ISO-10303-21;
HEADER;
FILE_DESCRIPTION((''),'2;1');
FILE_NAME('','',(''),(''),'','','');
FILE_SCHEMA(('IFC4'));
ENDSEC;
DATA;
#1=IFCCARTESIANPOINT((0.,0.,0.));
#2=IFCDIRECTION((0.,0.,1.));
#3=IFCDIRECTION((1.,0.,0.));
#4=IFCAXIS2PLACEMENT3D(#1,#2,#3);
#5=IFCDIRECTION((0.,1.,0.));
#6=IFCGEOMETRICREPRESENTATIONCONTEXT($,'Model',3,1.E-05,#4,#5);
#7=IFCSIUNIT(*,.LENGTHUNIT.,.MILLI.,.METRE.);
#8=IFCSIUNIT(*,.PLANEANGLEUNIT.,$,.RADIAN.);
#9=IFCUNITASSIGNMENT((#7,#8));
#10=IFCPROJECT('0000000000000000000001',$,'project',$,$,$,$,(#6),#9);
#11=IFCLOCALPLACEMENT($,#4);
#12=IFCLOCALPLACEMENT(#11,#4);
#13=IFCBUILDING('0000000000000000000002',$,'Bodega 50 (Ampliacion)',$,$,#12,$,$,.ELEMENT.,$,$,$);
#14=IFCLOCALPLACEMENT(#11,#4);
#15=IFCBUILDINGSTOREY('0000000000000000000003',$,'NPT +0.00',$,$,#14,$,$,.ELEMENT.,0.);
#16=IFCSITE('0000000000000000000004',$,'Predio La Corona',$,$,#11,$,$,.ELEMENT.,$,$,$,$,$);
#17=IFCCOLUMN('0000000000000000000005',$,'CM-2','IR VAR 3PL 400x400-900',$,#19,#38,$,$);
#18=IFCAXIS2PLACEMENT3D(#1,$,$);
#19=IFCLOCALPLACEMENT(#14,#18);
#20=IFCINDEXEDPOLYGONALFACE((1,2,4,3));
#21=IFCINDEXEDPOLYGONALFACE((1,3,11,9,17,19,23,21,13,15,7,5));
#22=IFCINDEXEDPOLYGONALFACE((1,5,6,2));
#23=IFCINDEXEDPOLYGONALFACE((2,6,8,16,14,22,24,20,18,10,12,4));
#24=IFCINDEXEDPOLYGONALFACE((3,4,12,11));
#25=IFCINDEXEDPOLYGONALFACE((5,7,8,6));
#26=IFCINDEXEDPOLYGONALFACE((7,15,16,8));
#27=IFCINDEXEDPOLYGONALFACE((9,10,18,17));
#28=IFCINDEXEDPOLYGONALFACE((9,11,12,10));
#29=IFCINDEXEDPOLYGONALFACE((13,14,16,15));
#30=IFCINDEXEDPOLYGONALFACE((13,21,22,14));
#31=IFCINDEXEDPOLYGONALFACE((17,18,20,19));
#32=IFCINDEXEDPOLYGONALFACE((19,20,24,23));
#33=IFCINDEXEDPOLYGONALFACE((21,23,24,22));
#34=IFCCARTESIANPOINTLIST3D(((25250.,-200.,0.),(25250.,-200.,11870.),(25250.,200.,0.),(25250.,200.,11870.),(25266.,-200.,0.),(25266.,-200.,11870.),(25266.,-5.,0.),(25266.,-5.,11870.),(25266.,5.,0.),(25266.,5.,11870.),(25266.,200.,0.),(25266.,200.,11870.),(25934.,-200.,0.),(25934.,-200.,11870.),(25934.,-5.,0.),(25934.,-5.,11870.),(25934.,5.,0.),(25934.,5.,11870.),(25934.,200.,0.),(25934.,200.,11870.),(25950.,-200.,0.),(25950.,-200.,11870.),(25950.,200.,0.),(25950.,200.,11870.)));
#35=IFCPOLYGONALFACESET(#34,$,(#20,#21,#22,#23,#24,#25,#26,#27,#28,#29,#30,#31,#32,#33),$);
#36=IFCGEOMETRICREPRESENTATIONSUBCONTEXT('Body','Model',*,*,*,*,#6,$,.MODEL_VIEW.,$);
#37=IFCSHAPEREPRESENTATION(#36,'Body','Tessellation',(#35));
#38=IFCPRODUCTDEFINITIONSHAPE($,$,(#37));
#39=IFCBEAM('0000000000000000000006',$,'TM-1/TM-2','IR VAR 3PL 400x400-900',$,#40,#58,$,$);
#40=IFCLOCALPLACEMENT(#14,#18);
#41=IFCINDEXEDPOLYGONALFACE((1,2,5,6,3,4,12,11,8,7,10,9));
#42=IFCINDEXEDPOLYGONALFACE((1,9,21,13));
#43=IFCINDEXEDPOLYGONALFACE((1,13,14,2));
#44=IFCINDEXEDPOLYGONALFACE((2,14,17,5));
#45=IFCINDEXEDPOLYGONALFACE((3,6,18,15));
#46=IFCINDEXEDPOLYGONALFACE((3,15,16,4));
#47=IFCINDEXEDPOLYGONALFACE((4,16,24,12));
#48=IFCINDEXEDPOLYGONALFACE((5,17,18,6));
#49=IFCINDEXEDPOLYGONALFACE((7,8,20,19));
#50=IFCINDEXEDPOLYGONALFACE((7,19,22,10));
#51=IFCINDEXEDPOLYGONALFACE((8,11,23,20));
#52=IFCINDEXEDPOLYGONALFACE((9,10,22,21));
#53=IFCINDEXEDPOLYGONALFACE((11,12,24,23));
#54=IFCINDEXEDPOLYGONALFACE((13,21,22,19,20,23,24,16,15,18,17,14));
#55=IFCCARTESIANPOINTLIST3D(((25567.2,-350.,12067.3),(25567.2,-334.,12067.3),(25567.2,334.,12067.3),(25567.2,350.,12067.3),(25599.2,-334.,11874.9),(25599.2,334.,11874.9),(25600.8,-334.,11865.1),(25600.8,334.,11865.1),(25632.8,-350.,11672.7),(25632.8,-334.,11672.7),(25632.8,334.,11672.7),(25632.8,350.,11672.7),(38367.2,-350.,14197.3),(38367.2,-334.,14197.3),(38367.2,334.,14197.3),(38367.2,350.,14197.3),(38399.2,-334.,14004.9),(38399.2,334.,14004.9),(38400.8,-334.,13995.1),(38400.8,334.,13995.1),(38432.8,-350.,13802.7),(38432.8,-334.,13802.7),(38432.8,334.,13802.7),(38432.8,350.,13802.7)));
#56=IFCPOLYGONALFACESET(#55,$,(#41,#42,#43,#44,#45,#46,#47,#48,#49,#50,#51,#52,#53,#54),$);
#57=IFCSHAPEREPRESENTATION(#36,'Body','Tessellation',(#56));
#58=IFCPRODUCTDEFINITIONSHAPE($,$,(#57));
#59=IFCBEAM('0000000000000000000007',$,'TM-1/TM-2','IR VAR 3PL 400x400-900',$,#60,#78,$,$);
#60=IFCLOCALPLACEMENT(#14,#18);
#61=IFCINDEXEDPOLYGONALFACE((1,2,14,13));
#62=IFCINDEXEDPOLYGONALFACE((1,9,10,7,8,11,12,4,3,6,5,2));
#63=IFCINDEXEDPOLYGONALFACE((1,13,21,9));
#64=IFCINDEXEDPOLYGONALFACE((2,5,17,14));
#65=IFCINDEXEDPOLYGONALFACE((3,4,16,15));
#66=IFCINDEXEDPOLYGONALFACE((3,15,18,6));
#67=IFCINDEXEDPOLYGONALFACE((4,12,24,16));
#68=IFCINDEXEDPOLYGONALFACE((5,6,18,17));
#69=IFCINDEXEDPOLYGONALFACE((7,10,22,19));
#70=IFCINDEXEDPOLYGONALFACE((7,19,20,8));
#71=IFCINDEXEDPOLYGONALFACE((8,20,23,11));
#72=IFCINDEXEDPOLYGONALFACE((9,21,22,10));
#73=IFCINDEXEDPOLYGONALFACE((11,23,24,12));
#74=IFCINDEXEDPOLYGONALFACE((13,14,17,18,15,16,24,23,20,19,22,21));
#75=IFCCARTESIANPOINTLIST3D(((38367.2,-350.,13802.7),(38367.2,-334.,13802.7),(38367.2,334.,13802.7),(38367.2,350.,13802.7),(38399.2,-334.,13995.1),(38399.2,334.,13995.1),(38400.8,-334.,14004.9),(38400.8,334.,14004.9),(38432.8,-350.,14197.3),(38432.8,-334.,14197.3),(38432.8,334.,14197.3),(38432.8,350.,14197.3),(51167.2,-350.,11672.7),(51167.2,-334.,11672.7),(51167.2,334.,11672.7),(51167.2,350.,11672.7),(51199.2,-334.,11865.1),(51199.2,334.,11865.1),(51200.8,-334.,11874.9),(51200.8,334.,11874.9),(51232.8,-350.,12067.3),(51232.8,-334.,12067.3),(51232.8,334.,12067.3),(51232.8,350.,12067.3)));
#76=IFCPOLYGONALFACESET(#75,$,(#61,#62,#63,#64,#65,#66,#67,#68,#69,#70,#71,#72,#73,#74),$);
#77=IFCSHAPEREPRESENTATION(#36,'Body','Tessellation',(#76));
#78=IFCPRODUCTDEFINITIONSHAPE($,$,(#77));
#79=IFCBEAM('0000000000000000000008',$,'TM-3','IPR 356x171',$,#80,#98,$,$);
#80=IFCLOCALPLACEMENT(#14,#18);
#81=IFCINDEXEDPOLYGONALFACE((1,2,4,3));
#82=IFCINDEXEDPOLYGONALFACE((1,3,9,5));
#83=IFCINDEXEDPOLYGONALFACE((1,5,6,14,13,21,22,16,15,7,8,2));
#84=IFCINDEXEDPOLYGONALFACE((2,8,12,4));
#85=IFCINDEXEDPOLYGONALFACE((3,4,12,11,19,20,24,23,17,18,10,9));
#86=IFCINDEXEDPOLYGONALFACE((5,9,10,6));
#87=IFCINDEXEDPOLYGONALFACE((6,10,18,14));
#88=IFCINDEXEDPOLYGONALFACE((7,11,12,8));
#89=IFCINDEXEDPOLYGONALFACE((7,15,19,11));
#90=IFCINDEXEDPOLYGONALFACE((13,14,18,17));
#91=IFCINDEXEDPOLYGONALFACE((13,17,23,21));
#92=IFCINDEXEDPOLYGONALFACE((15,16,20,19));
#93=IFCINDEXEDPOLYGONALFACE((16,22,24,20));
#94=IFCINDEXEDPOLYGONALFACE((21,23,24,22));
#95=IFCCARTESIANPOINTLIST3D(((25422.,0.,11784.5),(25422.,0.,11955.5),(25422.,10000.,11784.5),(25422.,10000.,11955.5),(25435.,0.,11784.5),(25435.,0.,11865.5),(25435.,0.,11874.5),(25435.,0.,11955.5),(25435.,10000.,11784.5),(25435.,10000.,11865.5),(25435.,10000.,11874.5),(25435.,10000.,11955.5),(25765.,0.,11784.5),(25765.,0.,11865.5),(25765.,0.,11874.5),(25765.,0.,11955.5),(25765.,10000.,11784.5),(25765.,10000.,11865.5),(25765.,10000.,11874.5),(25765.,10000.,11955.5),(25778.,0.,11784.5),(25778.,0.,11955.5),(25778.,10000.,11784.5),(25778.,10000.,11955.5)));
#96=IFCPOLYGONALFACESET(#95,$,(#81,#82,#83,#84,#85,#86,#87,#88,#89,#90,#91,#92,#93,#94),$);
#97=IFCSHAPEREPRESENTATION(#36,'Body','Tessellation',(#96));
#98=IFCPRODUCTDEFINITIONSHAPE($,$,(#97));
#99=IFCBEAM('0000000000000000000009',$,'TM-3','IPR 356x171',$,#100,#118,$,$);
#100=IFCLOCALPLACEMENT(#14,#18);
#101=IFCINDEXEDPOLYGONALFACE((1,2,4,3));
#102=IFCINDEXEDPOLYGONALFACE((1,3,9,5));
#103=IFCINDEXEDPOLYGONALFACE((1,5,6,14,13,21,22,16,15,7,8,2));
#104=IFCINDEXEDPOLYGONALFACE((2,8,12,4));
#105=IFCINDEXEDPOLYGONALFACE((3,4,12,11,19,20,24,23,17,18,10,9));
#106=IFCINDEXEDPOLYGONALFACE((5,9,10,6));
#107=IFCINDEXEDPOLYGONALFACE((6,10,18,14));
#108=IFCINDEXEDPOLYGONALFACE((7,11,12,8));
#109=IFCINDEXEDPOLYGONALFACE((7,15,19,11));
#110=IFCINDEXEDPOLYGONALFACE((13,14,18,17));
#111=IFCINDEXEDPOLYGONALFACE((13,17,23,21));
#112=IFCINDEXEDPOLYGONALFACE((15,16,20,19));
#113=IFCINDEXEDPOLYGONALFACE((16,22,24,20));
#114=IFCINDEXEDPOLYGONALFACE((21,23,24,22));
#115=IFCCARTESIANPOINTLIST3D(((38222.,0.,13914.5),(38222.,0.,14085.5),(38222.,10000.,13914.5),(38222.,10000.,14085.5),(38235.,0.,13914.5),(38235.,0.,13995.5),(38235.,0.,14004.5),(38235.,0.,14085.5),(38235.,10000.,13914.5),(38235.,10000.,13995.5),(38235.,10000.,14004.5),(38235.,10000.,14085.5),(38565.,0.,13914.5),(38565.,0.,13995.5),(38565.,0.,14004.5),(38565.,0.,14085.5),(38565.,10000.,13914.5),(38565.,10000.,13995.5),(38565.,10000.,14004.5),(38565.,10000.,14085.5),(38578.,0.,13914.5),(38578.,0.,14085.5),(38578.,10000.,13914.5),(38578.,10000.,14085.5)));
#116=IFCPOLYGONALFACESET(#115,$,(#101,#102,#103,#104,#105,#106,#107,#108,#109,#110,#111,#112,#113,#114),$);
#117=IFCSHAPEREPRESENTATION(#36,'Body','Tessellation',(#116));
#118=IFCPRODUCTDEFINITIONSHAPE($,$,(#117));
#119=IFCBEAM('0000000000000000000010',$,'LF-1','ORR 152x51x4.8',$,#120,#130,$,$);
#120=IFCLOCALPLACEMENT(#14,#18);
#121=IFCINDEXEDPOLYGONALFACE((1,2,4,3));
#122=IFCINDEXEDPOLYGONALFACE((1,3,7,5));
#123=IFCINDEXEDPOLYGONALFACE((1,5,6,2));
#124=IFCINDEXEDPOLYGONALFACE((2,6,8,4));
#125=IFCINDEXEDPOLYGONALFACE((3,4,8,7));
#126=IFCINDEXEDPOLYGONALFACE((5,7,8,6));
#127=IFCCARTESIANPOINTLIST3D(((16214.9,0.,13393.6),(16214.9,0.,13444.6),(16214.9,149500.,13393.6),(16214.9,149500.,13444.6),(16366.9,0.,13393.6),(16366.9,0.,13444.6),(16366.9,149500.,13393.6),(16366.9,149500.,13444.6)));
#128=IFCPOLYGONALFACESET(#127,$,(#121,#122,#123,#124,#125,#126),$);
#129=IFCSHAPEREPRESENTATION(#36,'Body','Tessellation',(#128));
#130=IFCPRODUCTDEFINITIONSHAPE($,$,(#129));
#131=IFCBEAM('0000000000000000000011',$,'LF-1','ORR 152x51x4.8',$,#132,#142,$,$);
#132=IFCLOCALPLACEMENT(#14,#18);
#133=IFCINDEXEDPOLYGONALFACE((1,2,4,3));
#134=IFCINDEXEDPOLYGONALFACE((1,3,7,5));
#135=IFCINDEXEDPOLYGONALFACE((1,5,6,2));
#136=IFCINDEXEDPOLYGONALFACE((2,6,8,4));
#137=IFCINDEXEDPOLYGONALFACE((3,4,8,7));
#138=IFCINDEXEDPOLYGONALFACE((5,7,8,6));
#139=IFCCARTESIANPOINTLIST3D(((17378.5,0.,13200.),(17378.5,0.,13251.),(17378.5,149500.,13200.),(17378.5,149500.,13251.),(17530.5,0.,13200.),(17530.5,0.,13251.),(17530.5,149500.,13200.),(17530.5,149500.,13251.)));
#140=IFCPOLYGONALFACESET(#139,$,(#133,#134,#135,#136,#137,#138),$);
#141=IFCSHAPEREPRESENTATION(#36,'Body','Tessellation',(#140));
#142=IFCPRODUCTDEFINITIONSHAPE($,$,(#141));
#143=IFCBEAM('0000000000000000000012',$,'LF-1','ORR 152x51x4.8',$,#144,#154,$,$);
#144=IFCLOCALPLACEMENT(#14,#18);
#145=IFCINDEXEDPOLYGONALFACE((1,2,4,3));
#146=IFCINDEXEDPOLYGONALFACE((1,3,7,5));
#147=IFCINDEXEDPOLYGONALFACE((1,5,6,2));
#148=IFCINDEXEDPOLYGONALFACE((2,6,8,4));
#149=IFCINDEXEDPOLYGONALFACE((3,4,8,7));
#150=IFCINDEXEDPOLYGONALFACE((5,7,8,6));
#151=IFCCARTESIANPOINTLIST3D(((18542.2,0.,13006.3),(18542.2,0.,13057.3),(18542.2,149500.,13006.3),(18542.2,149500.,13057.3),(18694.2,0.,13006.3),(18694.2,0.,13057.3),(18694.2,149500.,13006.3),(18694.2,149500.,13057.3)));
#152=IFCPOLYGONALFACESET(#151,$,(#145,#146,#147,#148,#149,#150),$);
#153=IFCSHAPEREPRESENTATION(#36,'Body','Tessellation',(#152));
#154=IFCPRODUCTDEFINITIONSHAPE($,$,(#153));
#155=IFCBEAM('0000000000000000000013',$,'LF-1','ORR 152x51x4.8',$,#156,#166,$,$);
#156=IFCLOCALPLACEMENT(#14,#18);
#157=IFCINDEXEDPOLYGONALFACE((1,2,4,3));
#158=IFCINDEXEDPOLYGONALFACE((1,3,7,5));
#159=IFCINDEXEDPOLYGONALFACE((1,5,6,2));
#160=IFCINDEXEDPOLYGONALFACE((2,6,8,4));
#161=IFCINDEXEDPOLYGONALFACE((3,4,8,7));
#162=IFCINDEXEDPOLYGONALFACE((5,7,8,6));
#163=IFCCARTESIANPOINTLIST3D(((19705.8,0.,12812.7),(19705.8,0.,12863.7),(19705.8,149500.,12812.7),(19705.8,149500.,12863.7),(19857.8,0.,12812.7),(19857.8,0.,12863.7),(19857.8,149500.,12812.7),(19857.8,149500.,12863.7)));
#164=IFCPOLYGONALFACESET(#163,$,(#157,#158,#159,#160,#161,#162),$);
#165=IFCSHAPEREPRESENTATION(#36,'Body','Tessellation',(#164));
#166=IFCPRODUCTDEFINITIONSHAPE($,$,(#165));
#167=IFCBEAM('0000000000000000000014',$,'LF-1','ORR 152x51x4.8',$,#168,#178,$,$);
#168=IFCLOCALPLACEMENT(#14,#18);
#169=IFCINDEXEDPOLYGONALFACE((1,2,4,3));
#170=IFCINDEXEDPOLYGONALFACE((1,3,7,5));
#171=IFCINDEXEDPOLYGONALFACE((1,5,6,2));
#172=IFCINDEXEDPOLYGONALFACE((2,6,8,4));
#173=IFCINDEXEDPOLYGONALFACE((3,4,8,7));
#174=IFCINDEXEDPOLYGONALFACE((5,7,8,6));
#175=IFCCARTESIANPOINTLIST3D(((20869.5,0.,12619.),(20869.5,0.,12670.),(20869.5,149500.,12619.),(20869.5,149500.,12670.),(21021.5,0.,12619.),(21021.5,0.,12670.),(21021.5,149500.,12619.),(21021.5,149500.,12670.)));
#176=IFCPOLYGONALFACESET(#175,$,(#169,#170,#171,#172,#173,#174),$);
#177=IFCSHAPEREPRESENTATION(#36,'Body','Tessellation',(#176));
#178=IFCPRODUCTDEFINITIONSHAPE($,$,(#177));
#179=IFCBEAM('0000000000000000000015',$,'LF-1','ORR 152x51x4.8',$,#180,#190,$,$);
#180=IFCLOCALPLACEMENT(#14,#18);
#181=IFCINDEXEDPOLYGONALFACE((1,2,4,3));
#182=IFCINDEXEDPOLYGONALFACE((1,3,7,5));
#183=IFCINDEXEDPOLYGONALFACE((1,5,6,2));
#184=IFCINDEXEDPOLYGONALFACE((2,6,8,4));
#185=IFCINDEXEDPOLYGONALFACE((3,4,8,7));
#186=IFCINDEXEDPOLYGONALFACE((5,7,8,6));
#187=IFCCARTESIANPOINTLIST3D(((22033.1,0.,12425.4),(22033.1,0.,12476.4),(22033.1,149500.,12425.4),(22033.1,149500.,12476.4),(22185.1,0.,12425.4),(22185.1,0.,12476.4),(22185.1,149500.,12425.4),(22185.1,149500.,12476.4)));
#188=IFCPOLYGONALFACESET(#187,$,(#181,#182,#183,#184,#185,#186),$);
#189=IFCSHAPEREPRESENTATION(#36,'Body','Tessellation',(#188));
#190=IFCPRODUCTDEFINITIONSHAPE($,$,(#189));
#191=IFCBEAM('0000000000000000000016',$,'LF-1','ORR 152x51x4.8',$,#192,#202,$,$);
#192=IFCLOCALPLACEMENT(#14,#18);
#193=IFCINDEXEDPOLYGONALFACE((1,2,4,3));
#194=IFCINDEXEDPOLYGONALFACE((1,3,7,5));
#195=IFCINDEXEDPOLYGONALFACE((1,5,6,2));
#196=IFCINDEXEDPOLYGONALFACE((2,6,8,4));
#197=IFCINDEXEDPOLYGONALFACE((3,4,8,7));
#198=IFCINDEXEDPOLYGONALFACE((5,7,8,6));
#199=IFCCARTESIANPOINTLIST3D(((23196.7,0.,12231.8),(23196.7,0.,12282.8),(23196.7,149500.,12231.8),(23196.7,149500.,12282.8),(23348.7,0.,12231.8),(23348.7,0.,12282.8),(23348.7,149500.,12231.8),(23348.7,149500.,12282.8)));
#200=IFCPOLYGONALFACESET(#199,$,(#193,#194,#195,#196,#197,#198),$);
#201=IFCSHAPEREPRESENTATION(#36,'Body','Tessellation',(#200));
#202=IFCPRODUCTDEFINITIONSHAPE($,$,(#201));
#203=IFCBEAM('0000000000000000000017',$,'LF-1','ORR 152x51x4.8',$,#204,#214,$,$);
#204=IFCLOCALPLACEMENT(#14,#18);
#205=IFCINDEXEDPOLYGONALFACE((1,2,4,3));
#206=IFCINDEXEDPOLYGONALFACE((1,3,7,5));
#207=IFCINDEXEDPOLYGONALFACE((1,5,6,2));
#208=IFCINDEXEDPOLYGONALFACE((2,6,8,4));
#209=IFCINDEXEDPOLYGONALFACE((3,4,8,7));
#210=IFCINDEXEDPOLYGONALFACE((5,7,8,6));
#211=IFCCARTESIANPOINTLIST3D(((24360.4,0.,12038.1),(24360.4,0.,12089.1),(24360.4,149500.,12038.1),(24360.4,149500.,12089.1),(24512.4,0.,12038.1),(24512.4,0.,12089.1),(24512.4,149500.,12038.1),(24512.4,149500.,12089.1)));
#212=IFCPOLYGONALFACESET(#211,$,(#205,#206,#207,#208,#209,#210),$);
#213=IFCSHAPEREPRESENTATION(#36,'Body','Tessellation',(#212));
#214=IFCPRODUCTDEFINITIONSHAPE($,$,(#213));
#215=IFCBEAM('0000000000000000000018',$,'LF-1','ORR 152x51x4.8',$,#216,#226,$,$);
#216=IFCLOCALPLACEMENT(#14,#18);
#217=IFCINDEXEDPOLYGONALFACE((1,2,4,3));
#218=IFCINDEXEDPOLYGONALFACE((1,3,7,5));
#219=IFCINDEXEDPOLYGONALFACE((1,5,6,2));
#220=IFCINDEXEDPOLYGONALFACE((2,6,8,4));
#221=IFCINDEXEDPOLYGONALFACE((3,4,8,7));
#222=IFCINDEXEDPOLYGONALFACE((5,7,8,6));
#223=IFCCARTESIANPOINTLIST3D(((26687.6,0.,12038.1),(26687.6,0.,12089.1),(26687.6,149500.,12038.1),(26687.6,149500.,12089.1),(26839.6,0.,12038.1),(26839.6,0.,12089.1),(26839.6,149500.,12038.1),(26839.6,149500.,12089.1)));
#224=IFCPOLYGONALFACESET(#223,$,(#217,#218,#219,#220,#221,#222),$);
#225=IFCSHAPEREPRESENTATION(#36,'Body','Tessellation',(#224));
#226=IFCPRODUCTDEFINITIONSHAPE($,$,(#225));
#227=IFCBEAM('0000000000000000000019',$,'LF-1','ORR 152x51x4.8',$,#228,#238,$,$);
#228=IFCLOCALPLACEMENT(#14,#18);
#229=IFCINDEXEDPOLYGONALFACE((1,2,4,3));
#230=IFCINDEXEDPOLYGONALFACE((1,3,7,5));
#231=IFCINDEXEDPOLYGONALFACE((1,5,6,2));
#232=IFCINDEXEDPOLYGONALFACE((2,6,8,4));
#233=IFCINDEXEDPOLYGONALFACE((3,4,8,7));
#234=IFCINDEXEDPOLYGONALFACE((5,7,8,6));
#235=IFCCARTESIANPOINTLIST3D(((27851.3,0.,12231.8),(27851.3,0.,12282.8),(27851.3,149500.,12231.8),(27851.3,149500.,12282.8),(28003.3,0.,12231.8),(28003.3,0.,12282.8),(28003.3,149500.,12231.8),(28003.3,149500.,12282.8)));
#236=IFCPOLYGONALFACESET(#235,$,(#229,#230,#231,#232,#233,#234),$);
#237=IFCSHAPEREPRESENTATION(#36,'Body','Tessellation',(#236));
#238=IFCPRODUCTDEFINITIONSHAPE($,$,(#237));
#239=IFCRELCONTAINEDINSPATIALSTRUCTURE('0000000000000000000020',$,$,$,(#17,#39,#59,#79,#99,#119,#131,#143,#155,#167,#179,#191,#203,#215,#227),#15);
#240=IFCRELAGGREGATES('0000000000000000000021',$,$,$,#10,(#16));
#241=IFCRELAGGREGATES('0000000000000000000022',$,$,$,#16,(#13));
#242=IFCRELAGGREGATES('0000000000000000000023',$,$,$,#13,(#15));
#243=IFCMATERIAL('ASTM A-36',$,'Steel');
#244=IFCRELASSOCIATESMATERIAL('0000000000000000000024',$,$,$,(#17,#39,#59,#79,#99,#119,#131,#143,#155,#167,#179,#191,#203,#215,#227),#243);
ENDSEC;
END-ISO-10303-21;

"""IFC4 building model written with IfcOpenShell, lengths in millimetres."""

from ifc_helpers import new_model, si_unit, direction, frame, origin_with_axes, origin_2d, place, context, subcontext, project, spatial, rectangle, i_section, extrude, material, element, save


model = new_model("IFC4")

# Units and contexts
model_context = context("Model", 3, precision=1e-05, world=origin_with_axes(), true_north=direction((0.0, 1.0, 0.0)))
body_context = subcontext(model_context, "Body", "Model", "MODEL_VIEW")
ifc_project = project(units=[si_unit("LENGTHUNIT", "METRE", prefix="MILLI"), si_unit("PLANEANGLEUNIT", "RADIAN")], contexts=[model_context])

# Site, building, storey
site_placement = place(None, origin_with_axes())
site = spatial("IfcSite", under=ifc_project, at=site_placement, Name="Predio La Corona", CompositionType="ELEMENT")
building_placement = place(site_placement, origin_with_axes())
building = spatial("IfcBuilding", under=site, at=building_placement, Name="Bodega 50 (Ampliacion)", CompositionType="ELEMENT")
storey_placement = place(site_placement, origin_with_axes())
storey = spatial("IfcBuildingStorey", under=building, at=storey_placement, Name="NPT +0.00", CompositionType="ELEMENT", Elevation=0.0)

# Column
ifc_material = material(Name="ASTM A-36", Category="Steel")
column_placement = place(storey_placement, frame((25600.0, 0.0, 0.0), z_axis=(0.0, 0.0, 1.0), x_axis=(0.0, -1.0, 0.0)))
element("IfcColumn", 1, at=column_placement, inside=storey, material=ifc_material, Name="CM-2", Description="IR VAR 3PL 400x400-900", context=body_context, shape_type="SweptSolid", body=[
    extrude(i_section(OverallWidth=400.0, OverallDepth=700.0, WebThickness=10.0, FlangeThickness=16.0, at=origin_2d()), origin_with_axes(), (0.0, 0.0, 1.0), 11870.0),
])

# Beams
for number, where, z_axis, x_axis, name in (
    (2, (25600.0, 0.0, 11870.0), (0.986436, 0.0, 0.164149), (0.164149, 0.0, -0.986436), "TM-1/TM-2"),
    (3, (38400.0, 0.0, 14000.0), (0.986436, 0.0, -0.164149), (-0.164149, 0.0, -0.986436), "TM-1/TM-2"),
):
    element("IfcBeam", number, at=place(storey_placement, frame(where, z_axis=z_axis, x_axis=x_axis)), inside=storey, material=ifc_material, Name=name, Description="IR VAR 3PL 400x400-900", context=body_context, shape_type="SweptSolid", body=[
        extrude(i_section(OverallWidth=400.0, OverallDepth=700.0, WebThickness=10.0, FlangeThickness=16.0, at=origin_2d()), origin_with_axes(), (0.0, 0.0, 1.0), 12976.0),
    ])
for number, where, z_axis, x_axis, name in (
    (4, (25600.0, 0.0, 11870.0), (0.0, 1.0, 0.0), (0.0, 0.0, 1.0), "TM-3"),
    (5, (38400.0, 0.0, 14000.0), (0.0, 1.0, 0.0), (0.0, 0.0, 1.0), "TM-3"),
):
    element("IfcBeam", number, at=place(storey_placement, frame(where, z_axis=z_axis, x_axis=x_axis)), inside=storey, material=ifc_material, Name=name, Description="IPR 356x171", context=body_context, shape_type="SweptSolid", body=[
        extrude(i_section(OverallWidth=171.0, OverallDepth=356.0, WebThickness=9.0, FlangeThickness=13.0, at=origin_2d()), origin_with_axes(), (0.0, 0.0, 1.0), 10000.0),
    ])
for number, where, z_axis, x_axis, name in (
    (6, (16290.9, 0.0, 13419.1), (0.0, 1.0, 0.0), (0.0, 0.0, 1.0), "LF-1"),
    (7, (17454.5, 0.0, 13225.5), (0.0, 1.0, 0.0), (0.0, 0.0, 1.0), "LF-1"),
    (8, (18618.2, 0.0, 13031.8), (0.0, 1.0, 0.0), (0.0, 0.0, 1.0), "LF-1"),
    (9, (19781.8, 0.0, 12838.2), (0.0, 1.0, 0.0), (0.0, 0.0, 1.0), "LF-1"),
    (10, (20945.5, 0.0, 12644.5), (0.0, 1.0, 0.0), (0.0, 0.0, 1.0), "LF-1"),
    (11, (22109.1, 0.0, 12450.9), (0.0, 1.0, 0.0), (0.0, 0.0, 1.0), "LF-1"),
    (12, (23272.7, 0.0, 12257.3), (0.0, 1.0, 0.0), (0.0, 0.0, 1.0), "LF-1"),
    (13, (24436.4, 0.0, 12063.6), (0.0, 1.0, 0.0), (0.0, 0.0, 1.0), "LF-1"),
    (14, (26763.6, 0.0, 12063.6), (0.0, 1.0, 0.0), (0.0, 0.0, 1.0), "LF-1"),
    (15, (27927.3, 0.0, 12257.3), (0.0, 1.0, 0.0), (0.0, 0.0, 1.0), "LF-1"),
):
    element("IfcBeam", number, at=place(storey_placement, frame(where, z_axis=z_axis, x_axis=x_axis)), inside=storey, material=ifc_material, Name=name, Description="ORR 152x51x4.8", context=body_context, shape_type="SweptSolid", body=[
        extrude(rectangle(XDim=51.0, YDim=152.0, at=origin_2d()), origin_with_axes(), (0.0, 0.0, 1.0), 149500.0),
    ])

save(model, "model.ifc")
